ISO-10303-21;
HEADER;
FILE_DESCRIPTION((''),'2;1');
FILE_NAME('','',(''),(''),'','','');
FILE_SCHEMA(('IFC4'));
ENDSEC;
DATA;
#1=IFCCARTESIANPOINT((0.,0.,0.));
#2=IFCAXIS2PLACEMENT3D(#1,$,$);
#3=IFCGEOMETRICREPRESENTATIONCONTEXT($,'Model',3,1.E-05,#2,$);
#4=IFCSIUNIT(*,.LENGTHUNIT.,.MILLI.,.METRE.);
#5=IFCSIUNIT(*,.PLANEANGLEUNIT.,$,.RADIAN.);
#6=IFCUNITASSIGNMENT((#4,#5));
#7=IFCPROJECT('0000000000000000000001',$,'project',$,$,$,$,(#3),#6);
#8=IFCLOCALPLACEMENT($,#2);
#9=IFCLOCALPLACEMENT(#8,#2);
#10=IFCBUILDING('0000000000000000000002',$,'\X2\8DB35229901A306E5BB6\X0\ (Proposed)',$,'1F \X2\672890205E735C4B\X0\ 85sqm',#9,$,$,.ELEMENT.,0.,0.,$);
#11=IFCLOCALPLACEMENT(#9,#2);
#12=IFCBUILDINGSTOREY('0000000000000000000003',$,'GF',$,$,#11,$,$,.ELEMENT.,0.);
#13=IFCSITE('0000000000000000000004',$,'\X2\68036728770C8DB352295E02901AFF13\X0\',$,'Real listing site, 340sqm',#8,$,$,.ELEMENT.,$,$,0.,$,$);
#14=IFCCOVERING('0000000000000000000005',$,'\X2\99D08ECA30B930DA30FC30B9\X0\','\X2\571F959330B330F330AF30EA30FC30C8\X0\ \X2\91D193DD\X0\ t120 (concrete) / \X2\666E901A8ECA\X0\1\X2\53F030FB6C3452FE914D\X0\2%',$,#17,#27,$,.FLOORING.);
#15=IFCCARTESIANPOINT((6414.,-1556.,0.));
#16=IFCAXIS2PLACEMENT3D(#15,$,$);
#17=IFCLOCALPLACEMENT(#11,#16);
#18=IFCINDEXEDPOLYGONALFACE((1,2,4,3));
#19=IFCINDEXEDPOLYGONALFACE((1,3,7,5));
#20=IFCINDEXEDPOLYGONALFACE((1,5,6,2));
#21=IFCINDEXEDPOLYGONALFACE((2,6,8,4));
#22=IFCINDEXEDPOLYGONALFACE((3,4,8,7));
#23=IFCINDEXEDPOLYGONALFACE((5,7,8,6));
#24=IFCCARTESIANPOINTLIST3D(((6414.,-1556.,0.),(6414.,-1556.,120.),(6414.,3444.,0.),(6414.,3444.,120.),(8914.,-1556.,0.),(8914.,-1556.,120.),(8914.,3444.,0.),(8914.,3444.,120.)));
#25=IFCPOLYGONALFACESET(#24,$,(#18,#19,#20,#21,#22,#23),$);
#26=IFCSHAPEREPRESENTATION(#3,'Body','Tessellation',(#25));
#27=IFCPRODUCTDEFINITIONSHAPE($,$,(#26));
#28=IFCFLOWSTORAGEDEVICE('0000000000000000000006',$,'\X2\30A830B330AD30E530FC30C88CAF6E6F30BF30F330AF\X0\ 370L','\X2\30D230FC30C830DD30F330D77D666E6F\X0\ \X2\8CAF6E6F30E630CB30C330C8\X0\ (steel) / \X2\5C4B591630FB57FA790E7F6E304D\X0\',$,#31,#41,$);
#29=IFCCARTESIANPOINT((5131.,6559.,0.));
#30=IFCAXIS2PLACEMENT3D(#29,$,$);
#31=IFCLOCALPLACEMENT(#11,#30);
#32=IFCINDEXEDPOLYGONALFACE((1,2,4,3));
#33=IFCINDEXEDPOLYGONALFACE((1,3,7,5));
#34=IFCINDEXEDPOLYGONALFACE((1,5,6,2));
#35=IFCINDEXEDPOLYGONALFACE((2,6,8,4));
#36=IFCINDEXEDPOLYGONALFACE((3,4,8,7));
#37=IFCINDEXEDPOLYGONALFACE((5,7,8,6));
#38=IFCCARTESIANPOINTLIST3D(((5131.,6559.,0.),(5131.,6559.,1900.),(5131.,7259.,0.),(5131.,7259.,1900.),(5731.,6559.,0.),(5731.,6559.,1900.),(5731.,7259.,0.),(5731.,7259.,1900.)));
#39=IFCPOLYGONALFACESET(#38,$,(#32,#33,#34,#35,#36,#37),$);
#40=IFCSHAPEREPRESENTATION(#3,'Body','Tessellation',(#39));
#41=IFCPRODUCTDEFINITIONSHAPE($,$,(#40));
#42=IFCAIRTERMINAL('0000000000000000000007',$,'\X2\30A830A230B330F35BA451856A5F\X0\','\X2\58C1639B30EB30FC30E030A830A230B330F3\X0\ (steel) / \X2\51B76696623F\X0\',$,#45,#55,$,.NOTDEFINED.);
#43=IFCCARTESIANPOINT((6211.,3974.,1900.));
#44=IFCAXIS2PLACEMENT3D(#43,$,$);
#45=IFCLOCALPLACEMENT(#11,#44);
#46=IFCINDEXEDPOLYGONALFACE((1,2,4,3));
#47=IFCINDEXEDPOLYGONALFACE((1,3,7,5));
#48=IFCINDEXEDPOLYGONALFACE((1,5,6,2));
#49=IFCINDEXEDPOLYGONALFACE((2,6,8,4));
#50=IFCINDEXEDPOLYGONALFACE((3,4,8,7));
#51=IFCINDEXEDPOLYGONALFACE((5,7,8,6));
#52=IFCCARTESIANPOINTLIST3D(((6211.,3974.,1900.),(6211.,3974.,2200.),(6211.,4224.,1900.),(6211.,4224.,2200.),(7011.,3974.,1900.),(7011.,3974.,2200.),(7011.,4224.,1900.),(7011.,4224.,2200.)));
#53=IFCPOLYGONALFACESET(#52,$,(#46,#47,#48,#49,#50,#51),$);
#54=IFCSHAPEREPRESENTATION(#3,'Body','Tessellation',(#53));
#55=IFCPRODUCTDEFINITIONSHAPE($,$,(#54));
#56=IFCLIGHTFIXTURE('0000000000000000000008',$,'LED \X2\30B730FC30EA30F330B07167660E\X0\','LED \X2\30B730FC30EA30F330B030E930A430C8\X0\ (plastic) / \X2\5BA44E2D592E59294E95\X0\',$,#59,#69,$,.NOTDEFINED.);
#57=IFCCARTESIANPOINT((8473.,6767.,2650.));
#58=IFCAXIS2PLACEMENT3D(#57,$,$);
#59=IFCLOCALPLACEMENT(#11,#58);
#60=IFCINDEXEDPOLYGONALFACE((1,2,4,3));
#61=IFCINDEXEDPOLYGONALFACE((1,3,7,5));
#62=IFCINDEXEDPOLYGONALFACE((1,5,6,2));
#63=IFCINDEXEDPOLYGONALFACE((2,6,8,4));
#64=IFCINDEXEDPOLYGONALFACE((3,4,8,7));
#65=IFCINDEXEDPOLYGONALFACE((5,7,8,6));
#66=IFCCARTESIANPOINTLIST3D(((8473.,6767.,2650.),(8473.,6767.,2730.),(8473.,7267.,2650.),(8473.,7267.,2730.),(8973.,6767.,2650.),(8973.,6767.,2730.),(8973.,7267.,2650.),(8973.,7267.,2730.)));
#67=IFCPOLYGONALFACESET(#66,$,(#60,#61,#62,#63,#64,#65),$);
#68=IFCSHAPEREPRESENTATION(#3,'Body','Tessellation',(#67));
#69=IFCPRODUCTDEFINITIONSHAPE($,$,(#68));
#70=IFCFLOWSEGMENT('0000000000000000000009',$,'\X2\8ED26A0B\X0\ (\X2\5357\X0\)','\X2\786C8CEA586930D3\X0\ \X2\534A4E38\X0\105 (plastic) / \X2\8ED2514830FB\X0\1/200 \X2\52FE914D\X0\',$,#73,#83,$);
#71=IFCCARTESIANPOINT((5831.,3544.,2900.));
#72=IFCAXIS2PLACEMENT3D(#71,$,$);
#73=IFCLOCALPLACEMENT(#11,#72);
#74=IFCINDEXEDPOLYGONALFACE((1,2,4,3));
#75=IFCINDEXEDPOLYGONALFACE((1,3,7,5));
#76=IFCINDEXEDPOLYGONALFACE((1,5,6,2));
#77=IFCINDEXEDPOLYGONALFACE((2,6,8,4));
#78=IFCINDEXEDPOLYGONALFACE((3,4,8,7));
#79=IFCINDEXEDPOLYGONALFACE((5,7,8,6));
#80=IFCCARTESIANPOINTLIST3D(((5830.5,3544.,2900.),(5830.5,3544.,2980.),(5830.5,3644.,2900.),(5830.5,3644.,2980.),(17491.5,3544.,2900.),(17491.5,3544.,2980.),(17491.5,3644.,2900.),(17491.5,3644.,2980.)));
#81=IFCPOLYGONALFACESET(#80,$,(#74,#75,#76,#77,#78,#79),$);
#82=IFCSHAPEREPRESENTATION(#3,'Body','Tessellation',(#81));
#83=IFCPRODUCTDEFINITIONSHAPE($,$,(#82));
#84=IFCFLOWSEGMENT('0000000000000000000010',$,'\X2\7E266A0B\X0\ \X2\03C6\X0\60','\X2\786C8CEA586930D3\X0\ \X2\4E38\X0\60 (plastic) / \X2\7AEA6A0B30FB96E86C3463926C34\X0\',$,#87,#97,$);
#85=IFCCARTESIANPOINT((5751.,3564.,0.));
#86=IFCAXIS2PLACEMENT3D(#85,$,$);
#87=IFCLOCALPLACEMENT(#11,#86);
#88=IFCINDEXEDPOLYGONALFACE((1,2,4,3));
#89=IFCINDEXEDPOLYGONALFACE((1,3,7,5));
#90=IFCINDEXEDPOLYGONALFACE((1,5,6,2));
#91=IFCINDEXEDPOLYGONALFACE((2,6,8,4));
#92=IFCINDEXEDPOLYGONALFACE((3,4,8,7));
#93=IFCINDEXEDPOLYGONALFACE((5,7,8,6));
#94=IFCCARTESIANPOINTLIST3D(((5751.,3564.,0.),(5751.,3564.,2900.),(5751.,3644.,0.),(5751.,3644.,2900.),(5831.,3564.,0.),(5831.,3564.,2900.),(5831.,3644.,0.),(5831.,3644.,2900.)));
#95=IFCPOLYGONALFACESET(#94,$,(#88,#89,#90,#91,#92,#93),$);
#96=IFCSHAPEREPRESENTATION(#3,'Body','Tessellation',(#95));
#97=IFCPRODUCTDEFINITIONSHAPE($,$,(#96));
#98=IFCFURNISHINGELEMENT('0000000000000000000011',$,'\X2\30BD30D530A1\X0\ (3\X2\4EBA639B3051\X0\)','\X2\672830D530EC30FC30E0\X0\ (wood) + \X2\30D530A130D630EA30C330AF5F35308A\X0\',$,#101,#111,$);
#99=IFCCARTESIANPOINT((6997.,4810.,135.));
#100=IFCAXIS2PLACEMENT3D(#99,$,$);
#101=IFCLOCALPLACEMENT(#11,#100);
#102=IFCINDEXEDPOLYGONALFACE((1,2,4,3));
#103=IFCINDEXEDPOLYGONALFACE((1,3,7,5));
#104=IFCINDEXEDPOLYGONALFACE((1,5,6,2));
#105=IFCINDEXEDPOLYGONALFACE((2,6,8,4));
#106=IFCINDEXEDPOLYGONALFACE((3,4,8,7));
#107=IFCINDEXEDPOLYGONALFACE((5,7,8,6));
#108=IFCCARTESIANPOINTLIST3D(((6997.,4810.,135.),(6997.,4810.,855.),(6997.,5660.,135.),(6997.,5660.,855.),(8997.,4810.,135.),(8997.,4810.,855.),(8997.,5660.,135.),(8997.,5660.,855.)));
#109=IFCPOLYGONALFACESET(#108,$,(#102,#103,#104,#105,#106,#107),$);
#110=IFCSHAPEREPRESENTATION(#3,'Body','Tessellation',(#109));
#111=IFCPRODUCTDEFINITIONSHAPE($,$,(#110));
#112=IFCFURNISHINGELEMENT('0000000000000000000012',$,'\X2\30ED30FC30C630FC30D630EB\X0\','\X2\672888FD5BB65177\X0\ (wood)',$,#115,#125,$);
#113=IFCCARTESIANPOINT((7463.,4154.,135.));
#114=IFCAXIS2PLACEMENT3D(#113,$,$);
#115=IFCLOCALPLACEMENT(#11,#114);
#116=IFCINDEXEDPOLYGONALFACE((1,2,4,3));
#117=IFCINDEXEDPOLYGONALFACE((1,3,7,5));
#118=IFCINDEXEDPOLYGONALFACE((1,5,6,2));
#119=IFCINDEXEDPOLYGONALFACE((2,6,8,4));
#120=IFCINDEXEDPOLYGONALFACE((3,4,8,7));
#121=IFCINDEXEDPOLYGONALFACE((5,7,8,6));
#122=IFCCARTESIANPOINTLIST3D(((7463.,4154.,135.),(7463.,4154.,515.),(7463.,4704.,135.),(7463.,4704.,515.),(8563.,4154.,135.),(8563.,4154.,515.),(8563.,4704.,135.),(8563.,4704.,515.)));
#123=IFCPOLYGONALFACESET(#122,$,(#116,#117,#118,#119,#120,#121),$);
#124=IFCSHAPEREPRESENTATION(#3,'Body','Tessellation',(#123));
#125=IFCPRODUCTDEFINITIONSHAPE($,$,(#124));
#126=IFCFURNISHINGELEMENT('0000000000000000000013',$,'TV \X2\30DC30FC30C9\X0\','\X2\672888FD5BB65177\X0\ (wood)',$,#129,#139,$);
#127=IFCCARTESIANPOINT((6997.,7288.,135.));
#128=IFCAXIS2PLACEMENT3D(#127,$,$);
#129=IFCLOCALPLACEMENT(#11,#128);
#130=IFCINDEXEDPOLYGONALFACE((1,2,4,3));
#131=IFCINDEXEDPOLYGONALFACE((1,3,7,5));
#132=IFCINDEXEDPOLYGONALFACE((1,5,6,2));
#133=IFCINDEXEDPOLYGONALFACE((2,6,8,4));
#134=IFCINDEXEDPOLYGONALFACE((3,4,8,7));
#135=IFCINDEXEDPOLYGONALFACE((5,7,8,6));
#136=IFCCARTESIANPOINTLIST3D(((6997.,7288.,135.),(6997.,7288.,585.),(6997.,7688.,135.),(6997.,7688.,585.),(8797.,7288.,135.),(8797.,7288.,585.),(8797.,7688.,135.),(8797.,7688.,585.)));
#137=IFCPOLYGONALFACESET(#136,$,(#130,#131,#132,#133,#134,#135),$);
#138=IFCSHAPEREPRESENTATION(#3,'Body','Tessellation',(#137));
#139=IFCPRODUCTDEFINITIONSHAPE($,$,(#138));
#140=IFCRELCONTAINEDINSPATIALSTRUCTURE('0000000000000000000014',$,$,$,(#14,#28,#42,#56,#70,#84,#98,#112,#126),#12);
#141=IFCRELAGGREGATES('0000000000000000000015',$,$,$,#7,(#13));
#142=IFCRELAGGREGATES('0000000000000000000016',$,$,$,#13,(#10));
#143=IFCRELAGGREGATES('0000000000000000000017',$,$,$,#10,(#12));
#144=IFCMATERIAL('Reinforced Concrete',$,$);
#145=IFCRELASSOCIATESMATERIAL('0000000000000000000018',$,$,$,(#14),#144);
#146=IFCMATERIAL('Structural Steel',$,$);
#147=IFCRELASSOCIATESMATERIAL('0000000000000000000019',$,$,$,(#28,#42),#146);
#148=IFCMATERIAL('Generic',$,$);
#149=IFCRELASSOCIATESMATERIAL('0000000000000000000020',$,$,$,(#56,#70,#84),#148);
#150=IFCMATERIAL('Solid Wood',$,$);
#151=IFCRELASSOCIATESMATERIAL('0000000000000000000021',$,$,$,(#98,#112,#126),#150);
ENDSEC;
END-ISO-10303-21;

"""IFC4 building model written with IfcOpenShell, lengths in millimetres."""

from ifc_helpers import new_model, si_unit, frame, frame_2d, origin, place, context, project, spatial, rectangle, extrude, material, element, save


model = new_model("IFC4")

# Units and contexts
model_context = context("Model", 3, precision=1e-05, world=origin())
ifc_project = project(units=[si_unit("LENGTHUNIT", "METRE", prefix="MILLI"), si_unit("PLANEANGLEUNIT", "RADIAN")], contexts=[model_context])

# Site, building, storey
site_placement = place(None, origin())
site = spatial("IfcSite", under=ifc_project, at=site_placement, Name="栃木県足利市通３", ObjectType="Real listing site, 340sqm", CompositionType="ELEMENT", RefElevation=0.0)
building_placement = place(site_placement, origin())
building = spatial("IfcBuilding", under=site, at=building_placement, Name="足利通の家 (Proposed)", ObjectType="1F 木造平屋 85sqm", CompositionType="ELEMENT", ElevationOfRefHeight=0.0, ElevationOfTerrain=0.0)
storey_placement = place(building_placement, origin())
storey = spatial("IfcBuildingStorey", under=building, at=storey_placement, Name="GF", CompositionType="ELEMENT", Elevation=0.0)

# Shared definitions
ifc_material_1 = material(Name="Solid Wood")

# Shared definitions
ifc_material_2 = material(Name="Reinforced Concrete")

# Shared definitions
ifc_material_3 = material(Name="Structural Steel")

# Covering
ifc_material_4 = material(Name="Generic")
covering_1_placement = place(storey_placement, frame((6414.0, -1556.0, 0.0)))
element("IfcCovering", 1, at=covering_1_placement, inside=storey, material=ifc_material_2, Name="駐車スペース", Description="土間コンクリート 金鏝 t120 (concrete) / 普通車1台・水勾配2%", PredefinedType="FLOORING", context=model_context, shape_type="SweptSolid", body=[
    extrude(rectangle(XDim=2500.0, YDim=5000.0, at=frame_2d((1250.0, 2500.0))), frame((6414.0, -1556.0, 0.0)), (0.0, 0.0, 1.0), 120.0),
])

# Flow storage device
flow_storage_device_placement = place(storey_placement, frame((5131.0, 6559.0, 0.0)))
element("IfcFlowStorageDevice", 2, at=flow_storage_device_placement, inside=storey, material=ifc_material_3, Name="エコキュート貯湯タンク 370L", Description="ヒートポンプ給湯 貯湯ユニット (steel) / 屋外・基礎置き", context=model_context, shape_type="SweptSolid", body=[
    extrude(rectangle(XDim=600.0, YDim=700.0, at=frame_2d((300.0, 350.0))), frame((5131.0, 6559.0, 0.0)), (0.0, 0.0, 1.0), 1900.0),
])

# Air terminal
air_terminal_placement = place(storey_placement, frame((6211.0, 3974.0, 1900.0)))
element("IfcAirTerminal", 3, at=air_terminal_placement, inside=storey, material=ifc_material_3, Name="エアコン室内機", Description="壁掛ルームエアコン (steel) / 冷暖房", PredefinedType="NOTDEFINED", context=model_context, shape_type="SweptSolid", body=[
    extrude(rectangle(XDim=800.0, YDim=250.0, at=frame_2d((400.0, 125.0))), frame((6211.0, 3974.0, 1900.0)), (0.0, 0.0, 1.0), 300.0),
])

# Light fixture
light_fixture_placement = place(storey_placement, frame((8473.0, 6767.0, 2650.0)))
element("IfcLightFixture", 4, at=light_fixture_placement, inside=storey, material=ifc_material_4, Name="LED シーリング照明", Description="LED シーリングライト (plastic) / 室中央天井", PredefinedType="NOTDEFINED", context=model_context, shape_type="SweptSolid", body=[
    extrude(rectangle(XDim=500.0, YDim=500.0, at=frame_2d((250.0, 250.0))), frame((8473.0, 6767.0, 2650.0)), (0.0, 0.0, 1.0), 80.0),
])

# Flow segments
flow_segment_1_placement = place(storey_placement, frame((5831.0, 3544.0, 2900.0)))
element("IfcFlowSegment", 5, at=flow_segment_1_placement, inside=storey, material=ifc_material_4, Name="軒樋 (南)", Description="硬質塩ビ 半丸105 (plastic) / 軒先・1/200 勾配", context=model_context, shape_type="SweptSolid", body=[
    extrude(rectangle(XDim=11661.0, YDim=100.0, at=frame_2d((5830.0, 50.0))), frame((5831.0, 3544.0, 2900.0)), (0.0, 0.0, 1.0), 80.0),
])
flow_segment_2_placement = place(storey_placement, frame((5751.0, 3564.0, 0.0)))
element("IfcFlowSegment", 6, at=flow_segment_2_placement, inside=storey, material=ifc_material_4, Name="縦樋 φ60", Description="硬質塩ビ 丸60 (plastic) / 竪樋・雨水排水", context=model_context, shape_type="SweptSolid", body=[
    extrude(rectangle(XDim=80.0, YDim=80.0, at=frame_2d((40.0, 40.0))), frame((5751.0, 3564.0, 0.0)), (0.0, 0.0, 1.0), 2900.0),
])

# Furnishing elements
furnishing_1_placement = place(storey_placement, frame((6997.0, 4810.0, 135.0)))
element("IfcFurnishingElement", 7, at=furnishing_1_placement, inside=storey, material=ifc_material_1, Name="ソファ (3人掛け)", Description="木フレーム (wood) + ファブリック張り", context=model_context, shape_type="SweptSolid", body=[
    extrude(rectangle(XDim=2000.0, YDim=850.0, at=frame_2d((1000.0, 425.0))), frame((6997.0, 4810.0, 135.0)), (0.0, 0.0, 1.0), 720.0),
])
furnishing_2_placement = place(storey_placement, frame((7463.0, 4154.0, 135.0)))
element("IfcFurnishingElement", 8, at=furnishing_2_placement, inside=storey, material=ifc_material_1, Name="ローテーブル", Description="木製家具 (wood)", context=model_context, shape_type="SweptSolid", body=[
    extrude(rectangle(XDim=1100.0, YDim=550.0, at=frame_2d((550.0, 275.0))), frame((7463.0, 4154.0, 135.0)), (0.0, 0.0, 1.0), 380.0),
])
furnishing_3_placement = place(storey_placement, frame((6997.0, 7288.0, 135.0)))
element("IfcFurnishingElement", 9, at=furnishing_3_placement, inside=storey, material=ifc_material_1, Name="TV ボード", Description="木製家具 (wood)", context=model_context, shape_type="SweptSolid", body=[
    extrude(rectangle(XDim=1800.0, YDim=400.0, at=frame_2d((900.0, 200.0))), frame((6997.0, 7288.0, 135.0)), (0.0, 0.0, 1.0), 450.0),
])

save(model, "model.ifc")
